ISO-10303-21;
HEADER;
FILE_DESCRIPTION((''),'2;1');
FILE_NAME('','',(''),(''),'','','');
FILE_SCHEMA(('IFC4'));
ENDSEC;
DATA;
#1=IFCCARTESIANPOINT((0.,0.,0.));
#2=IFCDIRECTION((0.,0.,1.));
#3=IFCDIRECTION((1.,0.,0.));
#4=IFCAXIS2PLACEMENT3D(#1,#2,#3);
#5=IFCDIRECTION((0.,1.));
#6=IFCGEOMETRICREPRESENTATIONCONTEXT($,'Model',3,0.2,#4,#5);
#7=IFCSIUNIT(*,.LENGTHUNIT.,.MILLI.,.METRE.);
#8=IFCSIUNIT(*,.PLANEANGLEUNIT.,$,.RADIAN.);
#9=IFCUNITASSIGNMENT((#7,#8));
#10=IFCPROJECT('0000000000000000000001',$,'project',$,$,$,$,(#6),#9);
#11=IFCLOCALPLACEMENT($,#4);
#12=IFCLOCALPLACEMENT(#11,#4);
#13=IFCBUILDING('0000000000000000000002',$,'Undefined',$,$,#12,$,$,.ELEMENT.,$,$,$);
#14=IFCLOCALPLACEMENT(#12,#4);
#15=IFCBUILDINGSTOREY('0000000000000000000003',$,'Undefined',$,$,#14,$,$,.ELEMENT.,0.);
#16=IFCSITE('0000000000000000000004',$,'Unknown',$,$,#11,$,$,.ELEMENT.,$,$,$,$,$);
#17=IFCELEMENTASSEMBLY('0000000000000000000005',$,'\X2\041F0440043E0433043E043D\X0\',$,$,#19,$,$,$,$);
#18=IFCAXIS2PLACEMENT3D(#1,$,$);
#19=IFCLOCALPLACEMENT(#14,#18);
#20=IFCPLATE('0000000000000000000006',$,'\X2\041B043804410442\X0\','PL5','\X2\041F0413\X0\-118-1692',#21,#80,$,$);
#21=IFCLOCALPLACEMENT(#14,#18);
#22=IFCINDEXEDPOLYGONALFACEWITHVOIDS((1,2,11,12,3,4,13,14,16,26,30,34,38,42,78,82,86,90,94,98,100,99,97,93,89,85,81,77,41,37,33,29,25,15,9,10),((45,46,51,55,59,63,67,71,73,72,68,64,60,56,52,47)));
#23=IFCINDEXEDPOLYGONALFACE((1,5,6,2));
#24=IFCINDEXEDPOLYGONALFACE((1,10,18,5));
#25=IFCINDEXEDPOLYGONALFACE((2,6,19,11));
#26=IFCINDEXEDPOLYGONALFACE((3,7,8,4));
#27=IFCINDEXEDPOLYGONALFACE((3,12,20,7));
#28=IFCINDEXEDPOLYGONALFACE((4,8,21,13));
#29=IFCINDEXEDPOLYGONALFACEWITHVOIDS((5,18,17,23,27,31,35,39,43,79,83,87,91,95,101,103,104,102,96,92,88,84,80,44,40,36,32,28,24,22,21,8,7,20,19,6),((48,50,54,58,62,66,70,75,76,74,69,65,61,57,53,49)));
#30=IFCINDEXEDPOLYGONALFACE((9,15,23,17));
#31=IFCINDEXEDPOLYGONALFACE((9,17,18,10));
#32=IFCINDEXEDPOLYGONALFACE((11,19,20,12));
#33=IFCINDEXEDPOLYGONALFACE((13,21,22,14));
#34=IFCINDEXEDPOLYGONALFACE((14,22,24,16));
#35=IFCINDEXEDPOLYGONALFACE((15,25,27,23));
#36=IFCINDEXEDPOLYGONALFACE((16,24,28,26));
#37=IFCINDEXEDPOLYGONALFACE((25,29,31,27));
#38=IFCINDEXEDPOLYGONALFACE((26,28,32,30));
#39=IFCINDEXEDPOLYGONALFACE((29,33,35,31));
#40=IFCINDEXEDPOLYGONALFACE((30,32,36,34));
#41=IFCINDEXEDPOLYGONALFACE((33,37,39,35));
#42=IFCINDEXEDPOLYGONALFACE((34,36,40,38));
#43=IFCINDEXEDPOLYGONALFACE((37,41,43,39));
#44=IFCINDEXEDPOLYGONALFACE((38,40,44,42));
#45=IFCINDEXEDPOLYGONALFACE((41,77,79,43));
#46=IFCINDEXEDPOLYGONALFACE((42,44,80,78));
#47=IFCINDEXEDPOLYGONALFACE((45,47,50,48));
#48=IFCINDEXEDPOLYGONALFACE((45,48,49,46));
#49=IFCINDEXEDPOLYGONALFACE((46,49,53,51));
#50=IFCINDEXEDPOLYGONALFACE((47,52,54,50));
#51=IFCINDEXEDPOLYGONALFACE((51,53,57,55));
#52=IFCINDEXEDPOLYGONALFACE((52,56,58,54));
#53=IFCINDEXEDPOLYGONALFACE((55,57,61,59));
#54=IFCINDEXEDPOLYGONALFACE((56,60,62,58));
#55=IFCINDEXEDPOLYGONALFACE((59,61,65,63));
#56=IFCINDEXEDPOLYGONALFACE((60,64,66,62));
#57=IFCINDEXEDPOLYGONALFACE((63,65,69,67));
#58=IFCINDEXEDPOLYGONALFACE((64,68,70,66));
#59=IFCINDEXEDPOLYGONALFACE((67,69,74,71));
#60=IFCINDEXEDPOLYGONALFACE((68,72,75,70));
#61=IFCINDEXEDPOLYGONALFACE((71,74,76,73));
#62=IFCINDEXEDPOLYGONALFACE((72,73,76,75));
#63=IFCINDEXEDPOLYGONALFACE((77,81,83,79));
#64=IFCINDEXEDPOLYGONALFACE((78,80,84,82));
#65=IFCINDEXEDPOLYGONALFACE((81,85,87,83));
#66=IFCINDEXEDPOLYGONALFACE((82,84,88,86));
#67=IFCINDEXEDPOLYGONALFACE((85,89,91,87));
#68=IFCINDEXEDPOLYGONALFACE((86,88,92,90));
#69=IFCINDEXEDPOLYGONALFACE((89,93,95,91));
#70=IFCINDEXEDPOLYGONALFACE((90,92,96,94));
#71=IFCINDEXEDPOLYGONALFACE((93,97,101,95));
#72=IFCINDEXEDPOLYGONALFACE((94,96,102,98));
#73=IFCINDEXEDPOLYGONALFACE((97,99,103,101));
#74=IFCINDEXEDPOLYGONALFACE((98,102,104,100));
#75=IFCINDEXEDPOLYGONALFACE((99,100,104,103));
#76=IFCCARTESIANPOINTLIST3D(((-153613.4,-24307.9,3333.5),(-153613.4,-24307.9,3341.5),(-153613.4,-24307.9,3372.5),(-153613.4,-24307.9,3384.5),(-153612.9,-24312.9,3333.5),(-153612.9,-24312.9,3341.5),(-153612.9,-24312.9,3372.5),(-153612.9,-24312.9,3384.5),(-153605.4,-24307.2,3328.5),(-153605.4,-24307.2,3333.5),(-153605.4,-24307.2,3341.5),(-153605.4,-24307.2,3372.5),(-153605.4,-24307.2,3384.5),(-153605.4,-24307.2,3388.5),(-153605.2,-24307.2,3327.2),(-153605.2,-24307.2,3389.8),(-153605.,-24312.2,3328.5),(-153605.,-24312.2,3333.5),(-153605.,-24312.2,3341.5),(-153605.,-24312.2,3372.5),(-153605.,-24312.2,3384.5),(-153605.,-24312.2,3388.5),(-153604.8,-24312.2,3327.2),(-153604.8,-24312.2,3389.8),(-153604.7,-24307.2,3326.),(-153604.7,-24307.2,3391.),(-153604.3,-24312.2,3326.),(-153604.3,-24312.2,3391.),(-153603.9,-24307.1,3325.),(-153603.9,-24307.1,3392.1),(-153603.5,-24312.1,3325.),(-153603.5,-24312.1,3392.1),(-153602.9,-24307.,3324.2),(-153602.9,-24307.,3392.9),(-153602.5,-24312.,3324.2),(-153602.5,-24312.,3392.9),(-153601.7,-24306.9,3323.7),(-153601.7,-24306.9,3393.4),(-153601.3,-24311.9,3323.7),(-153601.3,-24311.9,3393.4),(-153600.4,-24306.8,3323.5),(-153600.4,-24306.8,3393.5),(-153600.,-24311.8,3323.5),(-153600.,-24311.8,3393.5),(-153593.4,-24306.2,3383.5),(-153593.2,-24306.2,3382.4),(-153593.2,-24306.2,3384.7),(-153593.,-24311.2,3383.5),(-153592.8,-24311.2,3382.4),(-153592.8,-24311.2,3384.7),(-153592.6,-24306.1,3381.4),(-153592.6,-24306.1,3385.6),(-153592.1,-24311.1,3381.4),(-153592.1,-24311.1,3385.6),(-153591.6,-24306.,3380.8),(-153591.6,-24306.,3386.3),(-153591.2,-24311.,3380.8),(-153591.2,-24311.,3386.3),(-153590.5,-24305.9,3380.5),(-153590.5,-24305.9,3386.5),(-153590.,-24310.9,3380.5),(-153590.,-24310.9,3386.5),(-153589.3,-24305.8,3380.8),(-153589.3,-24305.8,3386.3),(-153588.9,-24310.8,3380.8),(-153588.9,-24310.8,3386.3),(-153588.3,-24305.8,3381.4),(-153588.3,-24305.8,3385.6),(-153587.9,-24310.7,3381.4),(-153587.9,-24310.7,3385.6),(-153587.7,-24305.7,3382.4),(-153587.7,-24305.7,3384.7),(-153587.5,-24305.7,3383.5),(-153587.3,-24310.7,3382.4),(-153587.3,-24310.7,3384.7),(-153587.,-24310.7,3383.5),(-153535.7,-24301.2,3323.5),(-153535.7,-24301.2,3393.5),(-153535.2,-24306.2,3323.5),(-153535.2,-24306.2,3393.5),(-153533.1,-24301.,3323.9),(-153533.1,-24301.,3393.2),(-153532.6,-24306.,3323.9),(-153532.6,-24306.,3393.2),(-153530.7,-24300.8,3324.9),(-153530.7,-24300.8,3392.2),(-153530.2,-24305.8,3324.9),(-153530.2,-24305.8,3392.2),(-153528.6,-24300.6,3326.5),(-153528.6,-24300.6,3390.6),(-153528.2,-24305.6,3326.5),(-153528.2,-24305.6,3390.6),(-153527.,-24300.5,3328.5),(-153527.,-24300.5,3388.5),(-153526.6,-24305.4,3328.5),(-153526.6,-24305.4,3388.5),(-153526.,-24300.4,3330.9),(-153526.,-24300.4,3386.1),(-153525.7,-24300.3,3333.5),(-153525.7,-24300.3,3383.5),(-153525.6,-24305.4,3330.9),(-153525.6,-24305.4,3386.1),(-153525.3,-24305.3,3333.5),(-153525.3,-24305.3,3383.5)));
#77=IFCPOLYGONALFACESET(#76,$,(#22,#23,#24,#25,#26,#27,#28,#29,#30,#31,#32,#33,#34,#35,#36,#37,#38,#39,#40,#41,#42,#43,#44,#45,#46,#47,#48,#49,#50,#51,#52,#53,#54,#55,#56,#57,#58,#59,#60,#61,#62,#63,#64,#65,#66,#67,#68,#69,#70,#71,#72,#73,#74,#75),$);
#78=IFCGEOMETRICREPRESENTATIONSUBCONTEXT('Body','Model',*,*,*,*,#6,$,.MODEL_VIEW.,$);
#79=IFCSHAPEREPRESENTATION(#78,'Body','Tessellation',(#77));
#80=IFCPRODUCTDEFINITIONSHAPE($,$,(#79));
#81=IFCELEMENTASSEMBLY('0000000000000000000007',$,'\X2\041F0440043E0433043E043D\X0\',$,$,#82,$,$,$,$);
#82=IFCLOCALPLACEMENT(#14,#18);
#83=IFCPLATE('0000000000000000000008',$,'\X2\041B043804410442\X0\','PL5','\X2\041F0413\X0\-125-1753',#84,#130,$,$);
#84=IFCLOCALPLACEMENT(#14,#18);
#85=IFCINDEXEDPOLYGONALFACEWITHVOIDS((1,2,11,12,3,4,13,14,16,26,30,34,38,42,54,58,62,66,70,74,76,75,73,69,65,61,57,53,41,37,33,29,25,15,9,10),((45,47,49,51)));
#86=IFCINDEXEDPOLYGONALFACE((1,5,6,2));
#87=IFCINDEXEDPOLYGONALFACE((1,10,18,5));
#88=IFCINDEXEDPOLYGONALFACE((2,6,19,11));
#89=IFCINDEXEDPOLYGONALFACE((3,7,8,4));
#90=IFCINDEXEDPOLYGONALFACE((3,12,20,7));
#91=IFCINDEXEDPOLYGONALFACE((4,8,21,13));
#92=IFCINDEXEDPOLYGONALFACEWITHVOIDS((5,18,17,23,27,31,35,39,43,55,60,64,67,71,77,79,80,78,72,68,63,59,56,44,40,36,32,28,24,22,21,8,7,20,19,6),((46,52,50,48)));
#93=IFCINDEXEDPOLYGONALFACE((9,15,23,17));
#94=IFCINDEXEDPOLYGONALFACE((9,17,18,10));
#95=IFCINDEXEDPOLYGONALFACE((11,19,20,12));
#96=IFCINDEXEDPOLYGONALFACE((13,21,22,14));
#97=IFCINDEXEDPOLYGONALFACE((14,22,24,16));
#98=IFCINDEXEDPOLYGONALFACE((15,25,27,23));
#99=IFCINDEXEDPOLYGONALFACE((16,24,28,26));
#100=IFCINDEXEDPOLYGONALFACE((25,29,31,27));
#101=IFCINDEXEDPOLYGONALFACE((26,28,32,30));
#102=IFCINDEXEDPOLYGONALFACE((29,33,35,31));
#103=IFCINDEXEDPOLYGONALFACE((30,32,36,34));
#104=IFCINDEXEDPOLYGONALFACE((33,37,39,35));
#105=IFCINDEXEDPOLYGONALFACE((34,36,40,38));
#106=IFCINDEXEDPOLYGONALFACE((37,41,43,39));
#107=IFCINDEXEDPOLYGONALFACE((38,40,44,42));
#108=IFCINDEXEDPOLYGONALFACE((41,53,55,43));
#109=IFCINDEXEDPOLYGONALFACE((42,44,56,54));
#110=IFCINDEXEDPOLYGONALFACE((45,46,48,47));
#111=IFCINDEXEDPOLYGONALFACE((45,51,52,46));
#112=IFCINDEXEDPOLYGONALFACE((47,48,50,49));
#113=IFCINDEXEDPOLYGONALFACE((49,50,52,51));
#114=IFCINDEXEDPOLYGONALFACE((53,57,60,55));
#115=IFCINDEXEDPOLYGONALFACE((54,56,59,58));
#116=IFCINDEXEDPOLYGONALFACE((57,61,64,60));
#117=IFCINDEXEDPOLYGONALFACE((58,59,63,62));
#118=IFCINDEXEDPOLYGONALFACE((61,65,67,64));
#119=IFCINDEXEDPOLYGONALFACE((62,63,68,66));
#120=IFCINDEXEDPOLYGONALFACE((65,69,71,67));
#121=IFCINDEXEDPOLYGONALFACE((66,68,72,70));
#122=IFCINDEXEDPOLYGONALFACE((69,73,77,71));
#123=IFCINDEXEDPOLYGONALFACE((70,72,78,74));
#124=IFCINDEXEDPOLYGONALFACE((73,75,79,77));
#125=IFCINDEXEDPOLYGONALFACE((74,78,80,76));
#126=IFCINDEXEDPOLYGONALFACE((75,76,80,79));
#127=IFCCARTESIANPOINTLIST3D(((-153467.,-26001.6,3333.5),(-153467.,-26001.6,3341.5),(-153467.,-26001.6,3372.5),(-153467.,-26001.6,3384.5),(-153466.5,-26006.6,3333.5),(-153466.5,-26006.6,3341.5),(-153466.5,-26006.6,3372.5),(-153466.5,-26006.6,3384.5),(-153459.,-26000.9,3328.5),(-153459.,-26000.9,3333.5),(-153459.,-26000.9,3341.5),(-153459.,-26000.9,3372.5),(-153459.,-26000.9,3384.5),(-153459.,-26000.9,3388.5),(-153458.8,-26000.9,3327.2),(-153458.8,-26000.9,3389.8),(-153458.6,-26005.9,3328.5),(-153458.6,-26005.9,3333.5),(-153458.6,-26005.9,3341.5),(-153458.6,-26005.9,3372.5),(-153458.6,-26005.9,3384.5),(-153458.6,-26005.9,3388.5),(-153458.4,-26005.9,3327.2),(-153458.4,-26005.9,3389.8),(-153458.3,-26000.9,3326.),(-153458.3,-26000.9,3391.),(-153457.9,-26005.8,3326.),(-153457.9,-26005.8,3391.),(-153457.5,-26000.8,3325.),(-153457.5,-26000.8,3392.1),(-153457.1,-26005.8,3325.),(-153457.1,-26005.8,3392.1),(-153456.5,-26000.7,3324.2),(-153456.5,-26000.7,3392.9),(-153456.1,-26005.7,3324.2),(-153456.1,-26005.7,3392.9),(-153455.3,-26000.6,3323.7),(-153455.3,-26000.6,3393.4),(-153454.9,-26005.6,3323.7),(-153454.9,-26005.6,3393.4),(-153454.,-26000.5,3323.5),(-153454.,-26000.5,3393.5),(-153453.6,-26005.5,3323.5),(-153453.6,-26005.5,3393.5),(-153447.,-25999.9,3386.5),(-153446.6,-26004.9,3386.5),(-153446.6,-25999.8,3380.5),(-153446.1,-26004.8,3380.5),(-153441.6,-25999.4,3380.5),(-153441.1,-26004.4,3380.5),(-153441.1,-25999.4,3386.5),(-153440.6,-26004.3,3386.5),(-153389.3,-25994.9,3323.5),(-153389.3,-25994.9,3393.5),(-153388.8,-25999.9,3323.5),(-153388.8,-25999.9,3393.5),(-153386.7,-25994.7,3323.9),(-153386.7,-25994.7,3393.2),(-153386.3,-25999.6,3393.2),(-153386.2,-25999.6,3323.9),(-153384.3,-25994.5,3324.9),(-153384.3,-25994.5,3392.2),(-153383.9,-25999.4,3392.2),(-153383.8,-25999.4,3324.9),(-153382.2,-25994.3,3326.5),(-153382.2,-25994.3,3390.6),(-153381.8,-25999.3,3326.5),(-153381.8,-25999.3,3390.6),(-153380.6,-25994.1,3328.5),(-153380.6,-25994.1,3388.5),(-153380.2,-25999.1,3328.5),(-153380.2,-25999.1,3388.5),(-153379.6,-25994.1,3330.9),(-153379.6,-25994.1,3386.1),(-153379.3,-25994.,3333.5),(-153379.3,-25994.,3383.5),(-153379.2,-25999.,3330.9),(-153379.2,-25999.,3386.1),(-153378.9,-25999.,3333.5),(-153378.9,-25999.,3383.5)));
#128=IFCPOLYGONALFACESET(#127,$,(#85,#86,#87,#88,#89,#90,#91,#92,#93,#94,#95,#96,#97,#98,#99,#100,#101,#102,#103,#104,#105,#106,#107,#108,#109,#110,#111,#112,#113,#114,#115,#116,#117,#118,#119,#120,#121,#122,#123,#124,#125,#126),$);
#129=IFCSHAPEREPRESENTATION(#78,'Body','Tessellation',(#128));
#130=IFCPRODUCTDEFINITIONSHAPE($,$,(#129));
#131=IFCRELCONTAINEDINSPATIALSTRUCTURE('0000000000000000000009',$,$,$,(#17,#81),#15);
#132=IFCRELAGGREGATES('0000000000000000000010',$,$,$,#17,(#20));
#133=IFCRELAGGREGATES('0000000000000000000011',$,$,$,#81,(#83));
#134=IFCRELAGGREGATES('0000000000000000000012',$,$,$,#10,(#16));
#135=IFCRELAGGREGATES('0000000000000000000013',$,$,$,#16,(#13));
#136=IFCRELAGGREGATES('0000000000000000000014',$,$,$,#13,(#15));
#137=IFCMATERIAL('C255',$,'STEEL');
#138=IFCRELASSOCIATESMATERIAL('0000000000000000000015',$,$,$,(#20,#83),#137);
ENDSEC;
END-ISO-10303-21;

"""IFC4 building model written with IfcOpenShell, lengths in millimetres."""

from ifc_helpers import new_model, si_unit, direction, frame, origin_with_axes, place, context, subcontext, project, spatial, line, arc, indexed_curve, outline, extrude, material, element, aggregate, save


model = new_model("IFC4")

# Units and contexts
model_context = context("Model", 3, precision=0.2, world=origin_with_axes(), true_north=direction((0.0, 1.0)))
body_context = subcontext(model_context, "Body", "Model", "MODEL_VIEW")
ifc_project = project(units=[si_unit("LENGTHUNIT", "METRE", prefix="MILLI"), si_unit("PLANEANGLEUNIT", "RADIAN")], contexts=[model_context])

# Site, building, storey
site_placement = place(None, origin_with_axes())
site = spatial("IfcSite", under=ifc_project, at=site_placement, Name="Unknown", CompositionType="ELEMENT")
building_placement = place(site_placement, origin_with_axes())
building = spatial("IfcBuilding", under=site, at=building_placement, Name="Undefined", CompositionType="ELEMENT")
storey_placement = place(building_placement, origin_with_axes())
storey = spatial("IfcBuildingStorey", under=building, at=storey_placement, Name="Undefined", CompositionType="ELEMENT", Elevation=0.0)

# Shared definitions
ifc_material_1 = material(Name="C255", Category="STEEL")

# Element assemblies, plates, voiding features
assembly_1_placement = place(storey_placement, frame((-153645.0, -24313.2, 3248.5), z_axis=(0.086114, -0.996285, 0.0), x_axis=(0.0, 0.0, 1.0)))
assembly_1 = element("IfcElementAssembly", 1, at=assembly_1_placement, inside=storey, Name="Прогон")
plate_1_placement = place(assembly_1_placement, frame((75.0, -120.0, 0.0), z_axis=(0.0, -0.000057, 1.0), x_axis=(1.0, 0.000078, 0.0)))
plate_1 = element("IfcPlate", 2, at=plate_1_placement, material=ifc_material_1, Name="Лист", Description="PL5", ObjectType="ПГ-118-1692", context=body_context, shape_type="SolidModel", body=[
    extrude(outline(indexed_curve([(0.0, 10.0), (2.9, 2.9), (10.0, 0.0), (60.0, 0.0), (67.1, 2.9), (70.0, 10.0), (70.0, 75.0), (68.5, 78.5), (65.0, 80.0), (61.0, 80.0), (61.0, 88.0), (49.0, 88.0), (49.0, 80.0), (18.0, 80.0), (18.0, 88.0), (10.0, 88.0), (10.0, 80.0), (5.0, 80.0), (1.5, 78.5), (0.0, 75.0)], segments=[arc(1, 2, 3), line(3, 4), arc(4, 5, 6), line(6, 7), arc(7, 8, 9), line(9, 10, 11, 12, 13, 14, 15, 16, 17, 18), arc(18, 19, 20), line(20, 1)])), frame((0.0, 0.0, 2.5), z_axis=(0.0, 0.0, 1.0), x_axis=(1.0, 0.0, 0.0)), (0.0, 0.0, -1.0), 5.0),
])
voiding_feature_1_placement = place(plate_1_placement, frame((60.0, 65.0, 6.0), z_axis=(-0.000054, -1.0, 0.000034), x_axis=(0.0, -0.000034, -1.0)))
element("IfcVoidingFeature", 3, at=voiding_feature_1_placement, cuts=plate_1, Name="Балка", ObjectType="(?)", PredefinedType="HOLE", context=body_context, shape_type="SolidModel", body=[
    extrude(outline(indexed_curve([(3.0, 0.0), (2.8, 1.1), (2.1, 2.1), (1.1, 2.8), (0.0, 3.0), (-1.1, 2.8), (-2.1, 2.1), (-2.8, 1.1), (-3.0, 0.0), (-2.8, -1.1), (-2.1, -2.1), (-1.1, -2.8), (0.0, -3.0), (1.1, -2.8), (2.1, -2.1), (2.8, -1.1)], segments=[line(1, 2, 3, 4, 5, 6, 7, 8, 9, 10, 11, 12, 13, 14, 15, 16, 1)])), frame((0.0, 0.0, 0.0), z_axis=(-1.0, 0.0, 0.0), x_axis=(0.0, 0.0, 1.0)), (0.0, 0.0, -1.0), 12.0),
])
aggregate(assembly_1, [plate_1])
assembly_2_placement = place(storey_placement, frame((-153498.6, -26006.9, 3248.5), z_axis=(0.086114, -0.996285, 0.0), x_axis=(0.0, 0.0, 1.0)))
assembly_2 = element("IfcElementAssembly", 4, at=assembly_2_placement, inside=storey, Name="Прогон")
plate_2_placement = place(assembly_2_placement, frame((75.0, -120.0, 0.0), z_axis=(0.0, -0.000057, 1.0), x_axis=(1.0, 0.000078, 0.0)))
plate_2 = element("IfcPlate", 5, at=plate_2_placement, material=ifc_material_1, Name="Лист", Description="PL5", ObjectType="ПГ-125-1753", context=body_context, shape_type="SolidModel", body=[
    extrude(outline(indexed_curve([(0.0, 10.0), (2.9, 2.9), (10.0, 0.0), (60.0, 0.0), (67.1, 2.9), (70.0, 10.0), (70.0, 75.0), (68.5, 78.5), (65.0, 80.0), (61.0, 80.0), (61.0, 88.0), (49.0, 88.0), (49.0, 80.0), (18.0, 80.0), (18.0, 88.0), (10.0, 88.0), (10.0, 80.0), (5.0, 80.0), (1.5, 78.5), (0.0, 75.0)], segments=[arc(1, 2, 3), line(3, 4), arc(4, 5, 6), line(6, 7), arc(7, 8, 9), line(9, 10, 11, 12, 13, 14, 15, 16, 17, 18), arc(18, 19, 20), line(20, 1)])), frame((0.0, 0.0, 2.5), z_axis=(0.0, 0.0, 1.0), x_axis=(1.0, 0.0, 0.0)), (0.0, 0.0, -1.0), 5.0),
])
voiding_feature_2_placement = place(plate_2_placement, frame((60.0, 65.0, 6.0), z_axis=(-0.000054, -1.0, 0.000034), x_axis=(0.0, -0.000034, -1.0)))
element("IfcVoidingFeature", 6, at=voiding_feature_2_placement, cuts=plate_2, Name="Балка", ObjectType="(?)", PredefinedType="HOLE", context=body_context, shape_type="SolidModel", body=[
    extrude(outline(indexed_curve([(2.5, -3.0), (3.0, 3.0), (-3.0, 3.0), (-2.5, -3.0)], segments=[line(1, 2, 3, 4, 1)])), frame((0.0, 0.0, 0.0), z_axis=(-1.0, 0.0, 0.0), x_axis=(0.0, 0.0, 1.0)), (0.0, 0.0, -1.0), 12.0),
])
aggregate(assembly_2, [plate_2])

save(model, "model.ifc")
